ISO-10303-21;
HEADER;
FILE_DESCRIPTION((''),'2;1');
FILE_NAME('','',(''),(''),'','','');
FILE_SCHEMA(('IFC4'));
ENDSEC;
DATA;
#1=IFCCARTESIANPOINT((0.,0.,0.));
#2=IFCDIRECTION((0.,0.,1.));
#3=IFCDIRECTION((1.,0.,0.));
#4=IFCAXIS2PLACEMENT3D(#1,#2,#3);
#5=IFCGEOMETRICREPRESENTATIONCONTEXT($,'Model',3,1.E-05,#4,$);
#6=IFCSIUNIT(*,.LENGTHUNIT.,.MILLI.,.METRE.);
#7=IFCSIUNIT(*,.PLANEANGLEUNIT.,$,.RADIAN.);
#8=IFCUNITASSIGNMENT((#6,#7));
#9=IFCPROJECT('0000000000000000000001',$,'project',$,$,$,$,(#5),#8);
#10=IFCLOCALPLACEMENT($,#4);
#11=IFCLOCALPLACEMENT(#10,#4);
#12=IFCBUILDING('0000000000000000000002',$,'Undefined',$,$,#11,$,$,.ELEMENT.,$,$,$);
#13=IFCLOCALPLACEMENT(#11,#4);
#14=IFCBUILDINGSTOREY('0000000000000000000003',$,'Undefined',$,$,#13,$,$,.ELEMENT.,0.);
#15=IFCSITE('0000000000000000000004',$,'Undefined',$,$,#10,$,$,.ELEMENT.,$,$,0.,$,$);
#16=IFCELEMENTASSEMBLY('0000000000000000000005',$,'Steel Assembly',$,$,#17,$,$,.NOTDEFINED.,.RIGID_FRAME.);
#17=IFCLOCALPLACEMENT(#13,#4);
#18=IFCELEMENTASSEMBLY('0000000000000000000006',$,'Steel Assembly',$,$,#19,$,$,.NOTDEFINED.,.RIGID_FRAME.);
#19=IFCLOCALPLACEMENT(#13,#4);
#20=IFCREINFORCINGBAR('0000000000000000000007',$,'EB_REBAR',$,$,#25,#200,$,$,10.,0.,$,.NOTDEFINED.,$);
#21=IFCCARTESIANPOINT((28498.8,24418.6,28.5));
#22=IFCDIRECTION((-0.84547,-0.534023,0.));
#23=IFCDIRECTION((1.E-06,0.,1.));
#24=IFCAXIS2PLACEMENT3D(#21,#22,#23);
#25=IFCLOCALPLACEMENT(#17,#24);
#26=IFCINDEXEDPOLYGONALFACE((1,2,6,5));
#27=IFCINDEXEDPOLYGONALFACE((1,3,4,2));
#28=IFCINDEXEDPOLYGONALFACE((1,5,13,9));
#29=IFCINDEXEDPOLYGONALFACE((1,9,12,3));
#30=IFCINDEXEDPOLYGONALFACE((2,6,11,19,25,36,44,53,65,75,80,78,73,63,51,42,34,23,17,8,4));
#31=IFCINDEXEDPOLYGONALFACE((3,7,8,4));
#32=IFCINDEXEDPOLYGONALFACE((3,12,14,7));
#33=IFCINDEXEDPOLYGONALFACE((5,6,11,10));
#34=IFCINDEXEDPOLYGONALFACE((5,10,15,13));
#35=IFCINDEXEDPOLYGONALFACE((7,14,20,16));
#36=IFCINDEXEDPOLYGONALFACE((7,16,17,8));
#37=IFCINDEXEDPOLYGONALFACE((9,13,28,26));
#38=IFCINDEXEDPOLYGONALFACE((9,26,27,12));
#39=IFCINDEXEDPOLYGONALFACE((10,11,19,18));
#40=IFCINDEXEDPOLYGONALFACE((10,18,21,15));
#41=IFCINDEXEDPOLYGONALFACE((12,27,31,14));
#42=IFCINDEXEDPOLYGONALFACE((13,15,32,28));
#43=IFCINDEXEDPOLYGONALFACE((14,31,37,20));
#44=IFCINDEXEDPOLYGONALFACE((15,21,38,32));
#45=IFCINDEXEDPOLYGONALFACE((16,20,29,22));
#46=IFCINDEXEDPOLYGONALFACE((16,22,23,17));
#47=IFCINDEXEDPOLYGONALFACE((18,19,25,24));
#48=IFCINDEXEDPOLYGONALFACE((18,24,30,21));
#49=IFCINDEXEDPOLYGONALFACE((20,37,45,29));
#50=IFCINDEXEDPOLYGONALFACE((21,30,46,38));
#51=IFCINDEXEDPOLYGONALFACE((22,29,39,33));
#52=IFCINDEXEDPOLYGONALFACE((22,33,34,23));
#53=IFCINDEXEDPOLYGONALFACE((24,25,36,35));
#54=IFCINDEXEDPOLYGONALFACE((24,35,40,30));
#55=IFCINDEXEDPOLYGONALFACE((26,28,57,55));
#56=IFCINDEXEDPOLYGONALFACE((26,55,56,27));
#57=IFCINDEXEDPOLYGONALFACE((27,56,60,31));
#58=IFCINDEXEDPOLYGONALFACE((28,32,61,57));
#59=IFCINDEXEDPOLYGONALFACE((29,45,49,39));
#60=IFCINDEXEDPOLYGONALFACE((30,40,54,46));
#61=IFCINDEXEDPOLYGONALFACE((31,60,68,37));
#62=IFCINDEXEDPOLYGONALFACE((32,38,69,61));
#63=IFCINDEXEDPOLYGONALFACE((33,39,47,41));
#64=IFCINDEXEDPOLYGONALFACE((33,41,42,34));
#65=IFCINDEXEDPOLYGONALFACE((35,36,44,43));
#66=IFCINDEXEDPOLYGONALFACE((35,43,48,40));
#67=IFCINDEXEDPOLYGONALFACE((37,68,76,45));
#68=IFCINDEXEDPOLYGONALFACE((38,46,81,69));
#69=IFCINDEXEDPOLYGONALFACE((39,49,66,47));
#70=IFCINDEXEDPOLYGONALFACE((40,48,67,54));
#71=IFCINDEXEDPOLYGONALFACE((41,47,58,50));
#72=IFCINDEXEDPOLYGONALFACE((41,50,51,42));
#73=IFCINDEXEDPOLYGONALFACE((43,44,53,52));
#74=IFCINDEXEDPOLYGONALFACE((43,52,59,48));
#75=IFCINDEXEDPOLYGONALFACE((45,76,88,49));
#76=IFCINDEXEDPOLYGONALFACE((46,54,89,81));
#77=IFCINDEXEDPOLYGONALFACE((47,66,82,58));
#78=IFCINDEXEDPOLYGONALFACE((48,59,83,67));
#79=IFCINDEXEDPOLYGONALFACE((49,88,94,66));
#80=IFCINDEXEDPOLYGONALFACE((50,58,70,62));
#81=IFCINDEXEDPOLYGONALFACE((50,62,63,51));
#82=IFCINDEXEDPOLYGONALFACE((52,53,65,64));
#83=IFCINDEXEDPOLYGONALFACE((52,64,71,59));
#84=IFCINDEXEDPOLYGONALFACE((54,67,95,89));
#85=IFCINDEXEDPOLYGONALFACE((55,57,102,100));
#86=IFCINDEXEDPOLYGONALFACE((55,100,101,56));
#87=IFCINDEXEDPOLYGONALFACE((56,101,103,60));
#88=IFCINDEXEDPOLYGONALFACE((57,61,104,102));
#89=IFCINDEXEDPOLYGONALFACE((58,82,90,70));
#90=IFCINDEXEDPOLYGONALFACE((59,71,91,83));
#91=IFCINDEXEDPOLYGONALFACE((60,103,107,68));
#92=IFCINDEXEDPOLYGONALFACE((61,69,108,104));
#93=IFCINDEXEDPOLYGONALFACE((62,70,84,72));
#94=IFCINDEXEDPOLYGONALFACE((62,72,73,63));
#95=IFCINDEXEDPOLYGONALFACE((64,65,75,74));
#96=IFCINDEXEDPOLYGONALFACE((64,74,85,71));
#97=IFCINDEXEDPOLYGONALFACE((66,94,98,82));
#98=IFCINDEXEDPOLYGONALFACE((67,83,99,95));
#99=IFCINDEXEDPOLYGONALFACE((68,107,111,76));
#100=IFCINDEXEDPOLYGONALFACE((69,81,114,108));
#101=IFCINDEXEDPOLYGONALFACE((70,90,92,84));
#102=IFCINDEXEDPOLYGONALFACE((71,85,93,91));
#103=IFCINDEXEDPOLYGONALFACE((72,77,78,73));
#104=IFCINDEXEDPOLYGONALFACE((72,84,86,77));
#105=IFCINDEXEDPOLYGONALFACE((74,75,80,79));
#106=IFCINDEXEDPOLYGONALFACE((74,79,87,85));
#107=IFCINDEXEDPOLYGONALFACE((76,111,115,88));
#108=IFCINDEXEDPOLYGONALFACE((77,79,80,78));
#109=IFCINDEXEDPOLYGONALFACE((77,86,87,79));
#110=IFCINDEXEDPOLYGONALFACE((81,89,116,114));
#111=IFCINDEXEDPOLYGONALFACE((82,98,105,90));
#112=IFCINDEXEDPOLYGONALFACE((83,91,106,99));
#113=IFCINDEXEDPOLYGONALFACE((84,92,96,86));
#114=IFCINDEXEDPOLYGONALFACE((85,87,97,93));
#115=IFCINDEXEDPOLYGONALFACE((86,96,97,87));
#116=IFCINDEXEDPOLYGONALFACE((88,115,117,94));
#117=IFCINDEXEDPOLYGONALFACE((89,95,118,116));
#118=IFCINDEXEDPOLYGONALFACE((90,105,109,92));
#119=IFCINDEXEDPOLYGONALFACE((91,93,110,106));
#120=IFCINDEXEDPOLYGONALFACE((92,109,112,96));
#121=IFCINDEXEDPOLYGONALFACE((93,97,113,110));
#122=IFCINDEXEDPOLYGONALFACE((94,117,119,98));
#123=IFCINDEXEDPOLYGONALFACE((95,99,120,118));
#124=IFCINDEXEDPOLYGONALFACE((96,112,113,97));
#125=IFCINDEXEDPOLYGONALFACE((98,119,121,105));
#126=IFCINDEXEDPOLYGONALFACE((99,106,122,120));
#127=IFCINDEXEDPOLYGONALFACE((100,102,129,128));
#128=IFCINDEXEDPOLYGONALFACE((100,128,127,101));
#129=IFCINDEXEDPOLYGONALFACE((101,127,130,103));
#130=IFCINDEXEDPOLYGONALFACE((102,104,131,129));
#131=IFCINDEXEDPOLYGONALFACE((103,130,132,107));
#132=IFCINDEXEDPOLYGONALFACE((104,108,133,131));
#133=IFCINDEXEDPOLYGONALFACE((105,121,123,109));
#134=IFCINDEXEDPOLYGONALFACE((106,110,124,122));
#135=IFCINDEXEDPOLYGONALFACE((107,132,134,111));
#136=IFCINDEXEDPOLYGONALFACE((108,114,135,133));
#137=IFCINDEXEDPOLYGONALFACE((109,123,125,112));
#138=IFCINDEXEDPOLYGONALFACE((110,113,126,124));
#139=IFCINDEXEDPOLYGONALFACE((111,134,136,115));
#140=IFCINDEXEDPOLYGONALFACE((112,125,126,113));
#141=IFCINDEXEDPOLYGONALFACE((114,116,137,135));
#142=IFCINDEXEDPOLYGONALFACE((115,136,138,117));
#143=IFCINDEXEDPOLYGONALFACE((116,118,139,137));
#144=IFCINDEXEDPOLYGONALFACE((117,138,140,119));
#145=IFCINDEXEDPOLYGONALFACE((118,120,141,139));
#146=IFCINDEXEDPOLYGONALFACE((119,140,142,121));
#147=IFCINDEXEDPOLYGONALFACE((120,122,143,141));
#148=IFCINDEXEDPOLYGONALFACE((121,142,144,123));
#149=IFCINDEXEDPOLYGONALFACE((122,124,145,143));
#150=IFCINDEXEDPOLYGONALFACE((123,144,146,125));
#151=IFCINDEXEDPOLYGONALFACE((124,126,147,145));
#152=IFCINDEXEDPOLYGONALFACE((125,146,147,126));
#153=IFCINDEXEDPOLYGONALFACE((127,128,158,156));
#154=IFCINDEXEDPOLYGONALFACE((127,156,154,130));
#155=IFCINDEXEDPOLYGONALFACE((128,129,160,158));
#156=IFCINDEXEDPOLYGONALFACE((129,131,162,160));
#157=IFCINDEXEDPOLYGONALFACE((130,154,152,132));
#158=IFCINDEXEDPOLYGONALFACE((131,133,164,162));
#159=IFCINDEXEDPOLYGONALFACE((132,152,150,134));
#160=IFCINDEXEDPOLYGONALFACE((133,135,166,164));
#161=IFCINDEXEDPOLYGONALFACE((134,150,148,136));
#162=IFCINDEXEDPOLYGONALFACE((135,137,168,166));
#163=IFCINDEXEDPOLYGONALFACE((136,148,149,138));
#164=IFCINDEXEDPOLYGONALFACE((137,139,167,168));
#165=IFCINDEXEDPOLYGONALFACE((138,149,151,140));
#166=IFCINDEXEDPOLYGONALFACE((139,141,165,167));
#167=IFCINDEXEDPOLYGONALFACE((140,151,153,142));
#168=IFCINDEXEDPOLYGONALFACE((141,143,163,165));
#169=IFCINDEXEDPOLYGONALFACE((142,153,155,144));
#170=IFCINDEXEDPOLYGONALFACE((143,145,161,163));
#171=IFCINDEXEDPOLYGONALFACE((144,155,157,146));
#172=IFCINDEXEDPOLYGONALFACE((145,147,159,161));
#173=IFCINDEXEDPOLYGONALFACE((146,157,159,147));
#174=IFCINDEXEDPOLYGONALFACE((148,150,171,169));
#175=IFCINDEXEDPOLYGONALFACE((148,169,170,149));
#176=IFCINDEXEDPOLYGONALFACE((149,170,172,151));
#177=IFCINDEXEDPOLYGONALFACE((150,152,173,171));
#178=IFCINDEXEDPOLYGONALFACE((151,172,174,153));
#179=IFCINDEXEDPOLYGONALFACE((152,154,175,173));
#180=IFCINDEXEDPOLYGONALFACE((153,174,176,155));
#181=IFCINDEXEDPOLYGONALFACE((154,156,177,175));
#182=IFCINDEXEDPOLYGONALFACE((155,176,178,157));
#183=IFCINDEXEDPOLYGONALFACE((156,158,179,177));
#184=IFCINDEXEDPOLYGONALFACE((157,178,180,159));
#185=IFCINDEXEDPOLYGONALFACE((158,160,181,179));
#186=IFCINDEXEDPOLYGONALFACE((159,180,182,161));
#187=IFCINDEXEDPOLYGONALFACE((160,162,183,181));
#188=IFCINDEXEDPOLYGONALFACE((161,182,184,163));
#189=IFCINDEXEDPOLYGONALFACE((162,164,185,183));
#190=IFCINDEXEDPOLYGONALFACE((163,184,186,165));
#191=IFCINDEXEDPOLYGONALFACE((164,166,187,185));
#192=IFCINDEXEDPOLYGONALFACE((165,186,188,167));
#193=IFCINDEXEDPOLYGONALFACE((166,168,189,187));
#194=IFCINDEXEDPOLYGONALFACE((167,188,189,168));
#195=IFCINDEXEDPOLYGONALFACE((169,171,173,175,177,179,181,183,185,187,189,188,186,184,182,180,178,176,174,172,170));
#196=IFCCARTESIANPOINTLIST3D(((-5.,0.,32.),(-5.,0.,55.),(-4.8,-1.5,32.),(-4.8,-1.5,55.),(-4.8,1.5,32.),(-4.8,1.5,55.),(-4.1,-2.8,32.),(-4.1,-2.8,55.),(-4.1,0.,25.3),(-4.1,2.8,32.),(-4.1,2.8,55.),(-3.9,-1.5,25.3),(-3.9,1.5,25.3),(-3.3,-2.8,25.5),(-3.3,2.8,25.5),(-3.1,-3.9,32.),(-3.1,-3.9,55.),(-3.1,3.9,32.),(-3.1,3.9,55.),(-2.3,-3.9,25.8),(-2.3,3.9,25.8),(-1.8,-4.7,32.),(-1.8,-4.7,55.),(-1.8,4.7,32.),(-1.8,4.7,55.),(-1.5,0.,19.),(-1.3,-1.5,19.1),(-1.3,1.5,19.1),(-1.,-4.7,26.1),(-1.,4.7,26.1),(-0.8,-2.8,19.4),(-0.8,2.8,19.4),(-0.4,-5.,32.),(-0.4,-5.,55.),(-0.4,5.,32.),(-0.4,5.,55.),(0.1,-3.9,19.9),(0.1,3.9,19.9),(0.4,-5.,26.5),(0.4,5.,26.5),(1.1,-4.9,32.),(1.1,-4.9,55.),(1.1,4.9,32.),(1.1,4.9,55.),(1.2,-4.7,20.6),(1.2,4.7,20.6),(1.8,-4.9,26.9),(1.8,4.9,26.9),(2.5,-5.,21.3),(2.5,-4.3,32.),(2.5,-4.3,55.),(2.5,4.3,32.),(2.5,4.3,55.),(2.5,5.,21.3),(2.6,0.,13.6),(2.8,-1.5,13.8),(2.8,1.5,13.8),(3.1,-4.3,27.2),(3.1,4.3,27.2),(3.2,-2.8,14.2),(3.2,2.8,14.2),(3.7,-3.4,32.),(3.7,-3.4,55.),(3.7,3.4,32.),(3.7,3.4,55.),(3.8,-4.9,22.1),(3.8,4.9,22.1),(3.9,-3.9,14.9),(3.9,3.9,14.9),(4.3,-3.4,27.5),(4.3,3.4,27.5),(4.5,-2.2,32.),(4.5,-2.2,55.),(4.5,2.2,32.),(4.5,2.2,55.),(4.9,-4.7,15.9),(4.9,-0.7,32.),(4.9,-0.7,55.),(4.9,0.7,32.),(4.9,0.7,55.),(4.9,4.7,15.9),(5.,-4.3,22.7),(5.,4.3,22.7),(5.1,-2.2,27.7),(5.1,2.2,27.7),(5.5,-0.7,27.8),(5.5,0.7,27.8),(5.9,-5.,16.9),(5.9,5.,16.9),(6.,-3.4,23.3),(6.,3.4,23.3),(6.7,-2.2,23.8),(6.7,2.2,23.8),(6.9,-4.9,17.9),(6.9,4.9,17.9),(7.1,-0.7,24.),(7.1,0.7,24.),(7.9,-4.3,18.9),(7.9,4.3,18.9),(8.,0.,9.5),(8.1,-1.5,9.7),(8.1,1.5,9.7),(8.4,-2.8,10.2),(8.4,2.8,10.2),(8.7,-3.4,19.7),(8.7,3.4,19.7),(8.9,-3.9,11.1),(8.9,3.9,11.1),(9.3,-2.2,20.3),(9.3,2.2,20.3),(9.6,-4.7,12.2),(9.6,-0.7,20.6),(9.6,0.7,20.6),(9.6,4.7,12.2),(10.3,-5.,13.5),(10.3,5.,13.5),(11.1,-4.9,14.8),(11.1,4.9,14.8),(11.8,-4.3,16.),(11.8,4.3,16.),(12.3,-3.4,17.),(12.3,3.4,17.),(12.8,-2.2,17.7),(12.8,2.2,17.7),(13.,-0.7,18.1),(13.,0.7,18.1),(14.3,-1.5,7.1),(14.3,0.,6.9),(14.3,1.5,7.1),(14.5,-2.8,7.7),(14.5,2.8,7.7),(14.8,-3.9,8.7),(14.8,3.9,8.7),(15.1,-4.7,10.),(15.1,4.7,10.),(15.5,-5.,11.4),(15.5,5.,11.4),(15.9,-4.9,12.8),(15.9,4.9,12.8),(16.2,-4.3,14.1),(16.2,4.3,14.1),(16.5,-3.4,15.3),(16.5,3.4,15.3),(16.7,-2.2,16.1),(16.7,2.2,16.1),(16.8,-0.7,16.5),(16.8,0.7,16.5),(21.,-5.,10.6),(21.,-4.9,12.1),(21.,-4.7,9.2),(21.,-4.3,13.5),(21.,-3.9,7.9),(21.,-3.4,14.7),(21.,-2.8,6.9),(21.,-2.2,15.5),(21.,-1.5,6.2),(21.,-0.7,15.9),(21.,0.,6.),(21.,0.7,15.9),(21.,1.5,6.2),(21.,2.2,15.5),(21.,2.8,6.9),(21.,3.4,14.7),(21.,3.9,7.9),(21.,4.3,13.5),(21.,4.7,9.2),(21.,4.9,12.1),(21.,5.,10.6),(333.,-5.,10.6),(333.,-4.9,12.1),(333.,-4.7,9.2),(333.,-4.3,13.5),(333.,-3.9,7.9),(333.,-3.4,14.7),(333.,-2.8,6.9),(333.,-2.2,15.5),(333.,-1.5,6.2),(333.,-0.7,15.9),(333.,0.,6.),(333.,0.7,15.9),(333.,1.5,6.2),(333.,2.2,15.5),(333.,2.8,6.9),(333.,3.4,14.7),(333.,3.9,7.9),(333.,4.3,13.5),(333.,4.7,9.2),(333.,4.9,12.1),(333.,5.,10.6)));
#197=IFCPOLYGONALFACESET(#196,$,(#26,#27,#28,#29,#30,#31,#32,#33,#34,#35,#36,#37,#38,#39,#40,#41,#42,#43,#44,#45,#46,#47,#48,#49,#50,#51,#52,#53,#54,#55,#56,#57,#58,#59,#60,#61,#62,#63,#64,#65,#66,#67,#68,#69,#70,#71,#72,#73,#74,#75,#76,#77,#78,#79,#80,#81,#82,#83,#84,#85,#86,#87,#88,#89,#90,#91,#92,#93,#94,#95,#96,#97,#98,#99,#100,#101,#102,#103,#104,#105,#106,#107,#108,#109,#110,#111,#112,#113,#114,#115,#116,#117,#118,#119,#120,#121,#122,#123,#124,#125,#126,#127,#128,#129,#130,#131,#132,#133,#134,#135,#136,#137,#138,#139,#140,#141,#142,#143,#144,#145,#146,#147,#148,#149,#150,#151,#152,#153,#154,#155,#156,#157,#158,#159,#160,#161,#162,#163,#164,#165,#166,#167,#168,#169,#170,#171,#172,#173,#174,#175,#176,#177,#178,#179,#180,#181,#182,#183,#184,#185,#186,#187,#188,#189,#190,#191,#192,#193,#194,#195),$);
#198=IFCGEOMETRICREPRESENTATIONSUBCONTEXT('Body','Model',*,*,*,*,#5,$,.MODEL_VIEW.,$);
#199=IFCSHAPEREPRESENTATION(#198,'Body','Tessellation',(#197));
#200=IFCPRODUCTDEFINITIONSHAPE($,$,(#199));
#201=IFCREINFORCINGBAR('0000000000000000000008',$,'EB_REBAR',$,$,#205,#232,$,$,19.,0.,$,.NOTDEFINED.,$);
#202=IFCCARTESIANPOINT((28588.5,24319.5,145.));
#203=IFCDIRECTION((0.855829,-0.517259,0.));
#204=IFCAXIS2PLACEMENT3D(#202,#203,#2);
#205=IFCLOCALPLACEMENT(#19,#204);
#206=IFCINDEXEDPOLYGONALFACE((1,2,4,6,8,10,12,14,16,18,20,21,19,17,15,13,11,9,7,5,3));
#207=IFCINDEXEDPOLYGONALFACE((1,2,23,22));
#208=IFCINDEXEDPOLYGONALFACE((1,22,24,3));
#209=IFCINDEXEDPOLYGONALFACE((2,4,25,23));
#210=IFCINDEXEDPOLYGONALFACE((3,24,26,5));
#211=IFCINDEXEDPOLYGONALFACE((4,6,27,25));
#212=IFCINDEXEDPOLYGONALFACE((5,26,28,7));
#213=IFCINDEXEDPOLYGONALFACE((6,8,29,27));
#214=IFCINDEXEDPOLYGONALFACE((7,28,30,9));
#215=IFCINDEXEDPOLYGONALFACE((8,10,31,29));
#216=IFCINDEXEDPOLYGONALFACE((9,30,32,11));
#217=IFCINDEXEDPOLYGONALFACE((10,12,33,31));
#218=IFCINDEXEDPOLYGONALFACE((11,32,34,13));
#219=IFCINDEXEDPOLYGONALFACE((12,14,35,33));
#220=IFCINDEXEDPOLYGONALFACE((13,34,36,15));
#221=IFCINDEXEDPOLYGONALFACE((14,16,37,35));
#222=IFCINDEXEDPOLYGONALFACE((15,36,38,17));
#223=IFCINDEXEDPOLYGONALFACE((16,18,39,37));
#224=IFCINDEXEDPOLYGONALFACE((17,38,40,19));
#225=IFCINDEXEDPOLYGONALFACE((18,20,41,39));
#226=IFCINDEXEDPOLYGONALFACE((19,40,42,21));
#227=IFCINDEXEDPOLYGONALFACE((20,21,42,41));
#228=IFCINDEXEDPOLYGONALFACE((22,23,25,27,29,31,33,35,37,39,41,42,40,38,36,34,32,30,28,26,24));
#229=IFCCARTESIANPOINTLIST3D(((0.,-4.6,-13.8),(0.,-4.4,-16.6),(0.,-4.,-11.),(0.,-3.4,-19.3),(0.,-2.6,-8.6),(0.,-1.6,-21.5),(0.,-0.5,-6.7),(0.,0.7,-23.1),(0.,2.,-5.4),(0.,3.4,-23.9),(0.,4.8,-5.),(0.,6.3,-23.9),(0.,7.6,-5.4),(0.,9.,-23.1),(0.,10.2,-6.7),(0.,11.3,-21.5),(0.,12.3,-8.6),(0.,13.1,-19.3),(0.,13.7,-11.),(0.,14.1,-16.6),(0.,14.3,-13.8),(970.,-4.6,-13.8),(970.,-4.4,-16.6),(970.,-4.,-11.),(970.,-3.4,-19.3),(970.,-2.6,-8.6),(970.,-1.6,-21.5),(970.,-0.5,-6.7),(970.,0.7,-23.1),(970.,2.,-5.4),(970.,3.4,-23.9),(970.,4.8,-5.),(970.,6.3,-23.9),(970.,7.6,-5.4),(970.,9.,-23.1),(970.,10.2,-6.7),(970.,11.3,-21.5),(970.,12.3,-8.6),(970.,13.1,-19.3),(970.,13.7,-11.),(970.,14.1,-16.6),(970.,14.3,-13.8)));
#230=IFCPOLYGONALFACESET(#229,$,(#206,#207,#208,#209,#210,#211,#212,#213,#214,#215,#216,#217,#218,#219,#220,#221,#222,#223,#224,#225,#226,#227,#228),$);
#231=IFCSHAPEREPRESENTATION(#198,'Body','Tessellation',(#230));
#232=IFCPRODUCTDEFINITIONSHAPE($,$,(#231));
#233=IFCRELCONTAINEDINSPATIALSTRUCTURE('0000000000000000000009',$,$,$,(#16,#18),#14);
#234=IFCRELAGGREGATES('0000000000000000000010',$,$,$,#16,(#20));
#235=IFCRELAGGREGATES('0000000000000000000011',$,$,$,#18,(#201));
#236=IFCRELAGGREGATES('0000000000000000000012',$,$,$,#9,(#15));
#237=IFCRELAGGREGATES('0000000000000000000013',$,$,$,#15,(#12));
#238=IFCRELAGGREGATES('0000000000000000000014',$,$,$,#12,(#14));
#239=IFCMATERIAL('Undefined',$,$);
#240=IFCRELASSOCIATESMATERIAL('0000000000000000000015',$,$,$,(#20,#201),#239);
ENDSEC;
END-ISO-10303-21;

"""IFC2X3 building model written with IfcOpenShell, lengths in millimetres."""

from ifc_helpers import new_model, entity, si_unit, frame, origin_with_axes, place, context, subcontext, project, spatial, source, transform, mapped, material, element, aggregate, save


model = new_model("IFC2X3")

# Units and contexts
model_context = context("Model", 3, precision=1e-05, world=origin_with_axes())
body_context = subcontext(model_context, "Body", "Model", "MODEL_VIEW")
ifc_project = project(units=[si_unit("LENGTHUNIT", "METRE", prefix="MILLI"), si_unit("PLANEANGLEUNIT", "RADIAN")], contexts=[model_context])

# Site, building, storey
site_placement = place(None, origin_with_axes())
site = spatial("IfcSite", under=ifc_project, at=site_placement, Name="Undefined", CompositionType="ELEMENT", RefElevation=0.0)
building_placement = place(site_placement, origin_with_axes())
building = spatial("IfcBuilding", under=site, at=building_placement, Name="Undefined", CompositionType="ELEMENT")
storey_placement = place(building_placement, origin_with_axes())
storey = spatial("IfcBuildingStorey", under=building, at=storey_placement, Name="Undefined", CompositionType="ELEMENT", Elevation=0.0)

# Element assemblies
assembly_1_placement = place(storey_placement, origin_with_axes())
assembly_1 = element("IfcElementAssembly", 1, at=assembly_1_placement, inside=storey, Name="Steel Assembly", AssemblyPlace="NOTDEFINED", PredefinedType="RIGID_FRAME")
assembly_2_placement = place(storey_placement, origin_with_axes())
assembly_2 = element("IfcElementAssembly", 2, at=assembly_2_placement, inside=storey, Name="Steel Assembly", AssemblyPlace="NOTDEFINED", PredefinedType="RIGID_FRAME")

# Shared definitions
ifc_material_1 = material(Name="Undefined")

# Reinforcing bars
shared_shape_1 = source(origin_with_axes(), body_context, "Body", "AdvancedSweptSolid", [
    entity("IfcSweptDiskSolid", entity("IfcCompositeCurve", [entity("IfcCompositeCurveSegment", "CONTINUOUS", True, entity("IfcTrimmedCurve", entity("IfcLine", entity("IfcCartesianPoint", [0.0, 0.0, 0.0]), entity("IfcVector", entity("IfcDirection", [0.0, 0.0, -1.0]), 1.0)), [entity("IfcParameterValue", 0.0)], [entity("IfcParameterValue", 23.004365)], True, "PARAMETER")), entity("IfcCompositeCurveSegment", "CONTINUOUS", True, entity("IfcTrimmedCurve", entity("IfcCircle", entity("IfcAxis2Placement3D", entity("IfcCartesianPoint", [21.0, 0.0, -23.0]), entity("IfcDirection", [0.0, -1.0, 0.0]), entity("IfcDirection", [-1.0, 0.0, 0.0])), 21.0), [entity("IfcParameterValue", 0.0)], [entity("IfcParameterValue", 1.570797)], True, "PARAMETER")), entity("IfcCompositeCurveSegment", "DISCONTINUOUS", True, entity("IfcTrimmedCurve", entity("IfcLine", entity("IfcCartesianPoint", [21.0, 0.0, -44.0]), entity("IfcVector", entity("IfcDirection", [1.0, 0.0, 0.0]), 1.0)), [entity("IfcParameterValue", 0.0)], [entity("IfcParameterValue", 311.999996)], True, "PARAMETER"))], False), 5.0, None, 0.0, 336.6),
])
reinforcing_bar_1_placement = place(assembly_1_placement, frame((28498.8, 24418.6, 28.5), z_axis=(-0.84547, -0.534023, 0.0), x_axis=(0.000001, 0.0, 1.0)))
reinforcing_bar_1 = element("IfcReinforcingBar", 3, at=reinforcing_bar_1_placement, material=ifc_material_1, Name="EB_REBAR", BarRole="NOTDEFINED", CrossSectionArea=0.0, NominalDiameter=10.0, context=body_context, shape_type="MappedRepresentation", body=[
    mapped(shared_shape_1, transform((0.0, 0.0, 55.0))),
])
aggregate(assembly_1, [reinforcing_bar_1])
shared_shape_2 = source(origin_with_axes(), body_context, "Body", "AdvancedSweptSolid", [
    entity("IfcSweptDiskSolid", entity("IfcTrimmedCurve", entity("IfcLine", entity("IfcCartesianPoint", [0.0, 0.0, 0.0]), entity("IfcVector", entity("IfcDirection", [1.0, 0.0, 0.0]), 1.0)), [entity("IfcParameterValue", 0.0)], [entity("IfcParameterValue", 969.999996)], True, "PARAMETER"), 9.5, None, 0.0, 970.0),
])
reinforcing_bar_2_placement = place(assembly_2_placement, frame((28588.5, 24319.5, 145.0), z_axis=(0.855829, -0.517259, 0.0), x_axis=(0.0, 0.0, 1.0)))
reinforcing_bar_2 = element("IfcReinforcingBar", 4, at=reinforcing_bar_2_placement, material=ifc_material_1, Name="EB_REBAR", BarRole="NOTDEFINED", CrossSectionArea=0.0, NominalDiameter=19.0, context=body_context, shape_type="MappedRepresentation", body=[
    mapped(shared_shape_2, transform((0.0, 4.8, -14.5))),
])
aggregate(assembly_2, [reinforcing_bar_2])

save(model, "model.ifc")
